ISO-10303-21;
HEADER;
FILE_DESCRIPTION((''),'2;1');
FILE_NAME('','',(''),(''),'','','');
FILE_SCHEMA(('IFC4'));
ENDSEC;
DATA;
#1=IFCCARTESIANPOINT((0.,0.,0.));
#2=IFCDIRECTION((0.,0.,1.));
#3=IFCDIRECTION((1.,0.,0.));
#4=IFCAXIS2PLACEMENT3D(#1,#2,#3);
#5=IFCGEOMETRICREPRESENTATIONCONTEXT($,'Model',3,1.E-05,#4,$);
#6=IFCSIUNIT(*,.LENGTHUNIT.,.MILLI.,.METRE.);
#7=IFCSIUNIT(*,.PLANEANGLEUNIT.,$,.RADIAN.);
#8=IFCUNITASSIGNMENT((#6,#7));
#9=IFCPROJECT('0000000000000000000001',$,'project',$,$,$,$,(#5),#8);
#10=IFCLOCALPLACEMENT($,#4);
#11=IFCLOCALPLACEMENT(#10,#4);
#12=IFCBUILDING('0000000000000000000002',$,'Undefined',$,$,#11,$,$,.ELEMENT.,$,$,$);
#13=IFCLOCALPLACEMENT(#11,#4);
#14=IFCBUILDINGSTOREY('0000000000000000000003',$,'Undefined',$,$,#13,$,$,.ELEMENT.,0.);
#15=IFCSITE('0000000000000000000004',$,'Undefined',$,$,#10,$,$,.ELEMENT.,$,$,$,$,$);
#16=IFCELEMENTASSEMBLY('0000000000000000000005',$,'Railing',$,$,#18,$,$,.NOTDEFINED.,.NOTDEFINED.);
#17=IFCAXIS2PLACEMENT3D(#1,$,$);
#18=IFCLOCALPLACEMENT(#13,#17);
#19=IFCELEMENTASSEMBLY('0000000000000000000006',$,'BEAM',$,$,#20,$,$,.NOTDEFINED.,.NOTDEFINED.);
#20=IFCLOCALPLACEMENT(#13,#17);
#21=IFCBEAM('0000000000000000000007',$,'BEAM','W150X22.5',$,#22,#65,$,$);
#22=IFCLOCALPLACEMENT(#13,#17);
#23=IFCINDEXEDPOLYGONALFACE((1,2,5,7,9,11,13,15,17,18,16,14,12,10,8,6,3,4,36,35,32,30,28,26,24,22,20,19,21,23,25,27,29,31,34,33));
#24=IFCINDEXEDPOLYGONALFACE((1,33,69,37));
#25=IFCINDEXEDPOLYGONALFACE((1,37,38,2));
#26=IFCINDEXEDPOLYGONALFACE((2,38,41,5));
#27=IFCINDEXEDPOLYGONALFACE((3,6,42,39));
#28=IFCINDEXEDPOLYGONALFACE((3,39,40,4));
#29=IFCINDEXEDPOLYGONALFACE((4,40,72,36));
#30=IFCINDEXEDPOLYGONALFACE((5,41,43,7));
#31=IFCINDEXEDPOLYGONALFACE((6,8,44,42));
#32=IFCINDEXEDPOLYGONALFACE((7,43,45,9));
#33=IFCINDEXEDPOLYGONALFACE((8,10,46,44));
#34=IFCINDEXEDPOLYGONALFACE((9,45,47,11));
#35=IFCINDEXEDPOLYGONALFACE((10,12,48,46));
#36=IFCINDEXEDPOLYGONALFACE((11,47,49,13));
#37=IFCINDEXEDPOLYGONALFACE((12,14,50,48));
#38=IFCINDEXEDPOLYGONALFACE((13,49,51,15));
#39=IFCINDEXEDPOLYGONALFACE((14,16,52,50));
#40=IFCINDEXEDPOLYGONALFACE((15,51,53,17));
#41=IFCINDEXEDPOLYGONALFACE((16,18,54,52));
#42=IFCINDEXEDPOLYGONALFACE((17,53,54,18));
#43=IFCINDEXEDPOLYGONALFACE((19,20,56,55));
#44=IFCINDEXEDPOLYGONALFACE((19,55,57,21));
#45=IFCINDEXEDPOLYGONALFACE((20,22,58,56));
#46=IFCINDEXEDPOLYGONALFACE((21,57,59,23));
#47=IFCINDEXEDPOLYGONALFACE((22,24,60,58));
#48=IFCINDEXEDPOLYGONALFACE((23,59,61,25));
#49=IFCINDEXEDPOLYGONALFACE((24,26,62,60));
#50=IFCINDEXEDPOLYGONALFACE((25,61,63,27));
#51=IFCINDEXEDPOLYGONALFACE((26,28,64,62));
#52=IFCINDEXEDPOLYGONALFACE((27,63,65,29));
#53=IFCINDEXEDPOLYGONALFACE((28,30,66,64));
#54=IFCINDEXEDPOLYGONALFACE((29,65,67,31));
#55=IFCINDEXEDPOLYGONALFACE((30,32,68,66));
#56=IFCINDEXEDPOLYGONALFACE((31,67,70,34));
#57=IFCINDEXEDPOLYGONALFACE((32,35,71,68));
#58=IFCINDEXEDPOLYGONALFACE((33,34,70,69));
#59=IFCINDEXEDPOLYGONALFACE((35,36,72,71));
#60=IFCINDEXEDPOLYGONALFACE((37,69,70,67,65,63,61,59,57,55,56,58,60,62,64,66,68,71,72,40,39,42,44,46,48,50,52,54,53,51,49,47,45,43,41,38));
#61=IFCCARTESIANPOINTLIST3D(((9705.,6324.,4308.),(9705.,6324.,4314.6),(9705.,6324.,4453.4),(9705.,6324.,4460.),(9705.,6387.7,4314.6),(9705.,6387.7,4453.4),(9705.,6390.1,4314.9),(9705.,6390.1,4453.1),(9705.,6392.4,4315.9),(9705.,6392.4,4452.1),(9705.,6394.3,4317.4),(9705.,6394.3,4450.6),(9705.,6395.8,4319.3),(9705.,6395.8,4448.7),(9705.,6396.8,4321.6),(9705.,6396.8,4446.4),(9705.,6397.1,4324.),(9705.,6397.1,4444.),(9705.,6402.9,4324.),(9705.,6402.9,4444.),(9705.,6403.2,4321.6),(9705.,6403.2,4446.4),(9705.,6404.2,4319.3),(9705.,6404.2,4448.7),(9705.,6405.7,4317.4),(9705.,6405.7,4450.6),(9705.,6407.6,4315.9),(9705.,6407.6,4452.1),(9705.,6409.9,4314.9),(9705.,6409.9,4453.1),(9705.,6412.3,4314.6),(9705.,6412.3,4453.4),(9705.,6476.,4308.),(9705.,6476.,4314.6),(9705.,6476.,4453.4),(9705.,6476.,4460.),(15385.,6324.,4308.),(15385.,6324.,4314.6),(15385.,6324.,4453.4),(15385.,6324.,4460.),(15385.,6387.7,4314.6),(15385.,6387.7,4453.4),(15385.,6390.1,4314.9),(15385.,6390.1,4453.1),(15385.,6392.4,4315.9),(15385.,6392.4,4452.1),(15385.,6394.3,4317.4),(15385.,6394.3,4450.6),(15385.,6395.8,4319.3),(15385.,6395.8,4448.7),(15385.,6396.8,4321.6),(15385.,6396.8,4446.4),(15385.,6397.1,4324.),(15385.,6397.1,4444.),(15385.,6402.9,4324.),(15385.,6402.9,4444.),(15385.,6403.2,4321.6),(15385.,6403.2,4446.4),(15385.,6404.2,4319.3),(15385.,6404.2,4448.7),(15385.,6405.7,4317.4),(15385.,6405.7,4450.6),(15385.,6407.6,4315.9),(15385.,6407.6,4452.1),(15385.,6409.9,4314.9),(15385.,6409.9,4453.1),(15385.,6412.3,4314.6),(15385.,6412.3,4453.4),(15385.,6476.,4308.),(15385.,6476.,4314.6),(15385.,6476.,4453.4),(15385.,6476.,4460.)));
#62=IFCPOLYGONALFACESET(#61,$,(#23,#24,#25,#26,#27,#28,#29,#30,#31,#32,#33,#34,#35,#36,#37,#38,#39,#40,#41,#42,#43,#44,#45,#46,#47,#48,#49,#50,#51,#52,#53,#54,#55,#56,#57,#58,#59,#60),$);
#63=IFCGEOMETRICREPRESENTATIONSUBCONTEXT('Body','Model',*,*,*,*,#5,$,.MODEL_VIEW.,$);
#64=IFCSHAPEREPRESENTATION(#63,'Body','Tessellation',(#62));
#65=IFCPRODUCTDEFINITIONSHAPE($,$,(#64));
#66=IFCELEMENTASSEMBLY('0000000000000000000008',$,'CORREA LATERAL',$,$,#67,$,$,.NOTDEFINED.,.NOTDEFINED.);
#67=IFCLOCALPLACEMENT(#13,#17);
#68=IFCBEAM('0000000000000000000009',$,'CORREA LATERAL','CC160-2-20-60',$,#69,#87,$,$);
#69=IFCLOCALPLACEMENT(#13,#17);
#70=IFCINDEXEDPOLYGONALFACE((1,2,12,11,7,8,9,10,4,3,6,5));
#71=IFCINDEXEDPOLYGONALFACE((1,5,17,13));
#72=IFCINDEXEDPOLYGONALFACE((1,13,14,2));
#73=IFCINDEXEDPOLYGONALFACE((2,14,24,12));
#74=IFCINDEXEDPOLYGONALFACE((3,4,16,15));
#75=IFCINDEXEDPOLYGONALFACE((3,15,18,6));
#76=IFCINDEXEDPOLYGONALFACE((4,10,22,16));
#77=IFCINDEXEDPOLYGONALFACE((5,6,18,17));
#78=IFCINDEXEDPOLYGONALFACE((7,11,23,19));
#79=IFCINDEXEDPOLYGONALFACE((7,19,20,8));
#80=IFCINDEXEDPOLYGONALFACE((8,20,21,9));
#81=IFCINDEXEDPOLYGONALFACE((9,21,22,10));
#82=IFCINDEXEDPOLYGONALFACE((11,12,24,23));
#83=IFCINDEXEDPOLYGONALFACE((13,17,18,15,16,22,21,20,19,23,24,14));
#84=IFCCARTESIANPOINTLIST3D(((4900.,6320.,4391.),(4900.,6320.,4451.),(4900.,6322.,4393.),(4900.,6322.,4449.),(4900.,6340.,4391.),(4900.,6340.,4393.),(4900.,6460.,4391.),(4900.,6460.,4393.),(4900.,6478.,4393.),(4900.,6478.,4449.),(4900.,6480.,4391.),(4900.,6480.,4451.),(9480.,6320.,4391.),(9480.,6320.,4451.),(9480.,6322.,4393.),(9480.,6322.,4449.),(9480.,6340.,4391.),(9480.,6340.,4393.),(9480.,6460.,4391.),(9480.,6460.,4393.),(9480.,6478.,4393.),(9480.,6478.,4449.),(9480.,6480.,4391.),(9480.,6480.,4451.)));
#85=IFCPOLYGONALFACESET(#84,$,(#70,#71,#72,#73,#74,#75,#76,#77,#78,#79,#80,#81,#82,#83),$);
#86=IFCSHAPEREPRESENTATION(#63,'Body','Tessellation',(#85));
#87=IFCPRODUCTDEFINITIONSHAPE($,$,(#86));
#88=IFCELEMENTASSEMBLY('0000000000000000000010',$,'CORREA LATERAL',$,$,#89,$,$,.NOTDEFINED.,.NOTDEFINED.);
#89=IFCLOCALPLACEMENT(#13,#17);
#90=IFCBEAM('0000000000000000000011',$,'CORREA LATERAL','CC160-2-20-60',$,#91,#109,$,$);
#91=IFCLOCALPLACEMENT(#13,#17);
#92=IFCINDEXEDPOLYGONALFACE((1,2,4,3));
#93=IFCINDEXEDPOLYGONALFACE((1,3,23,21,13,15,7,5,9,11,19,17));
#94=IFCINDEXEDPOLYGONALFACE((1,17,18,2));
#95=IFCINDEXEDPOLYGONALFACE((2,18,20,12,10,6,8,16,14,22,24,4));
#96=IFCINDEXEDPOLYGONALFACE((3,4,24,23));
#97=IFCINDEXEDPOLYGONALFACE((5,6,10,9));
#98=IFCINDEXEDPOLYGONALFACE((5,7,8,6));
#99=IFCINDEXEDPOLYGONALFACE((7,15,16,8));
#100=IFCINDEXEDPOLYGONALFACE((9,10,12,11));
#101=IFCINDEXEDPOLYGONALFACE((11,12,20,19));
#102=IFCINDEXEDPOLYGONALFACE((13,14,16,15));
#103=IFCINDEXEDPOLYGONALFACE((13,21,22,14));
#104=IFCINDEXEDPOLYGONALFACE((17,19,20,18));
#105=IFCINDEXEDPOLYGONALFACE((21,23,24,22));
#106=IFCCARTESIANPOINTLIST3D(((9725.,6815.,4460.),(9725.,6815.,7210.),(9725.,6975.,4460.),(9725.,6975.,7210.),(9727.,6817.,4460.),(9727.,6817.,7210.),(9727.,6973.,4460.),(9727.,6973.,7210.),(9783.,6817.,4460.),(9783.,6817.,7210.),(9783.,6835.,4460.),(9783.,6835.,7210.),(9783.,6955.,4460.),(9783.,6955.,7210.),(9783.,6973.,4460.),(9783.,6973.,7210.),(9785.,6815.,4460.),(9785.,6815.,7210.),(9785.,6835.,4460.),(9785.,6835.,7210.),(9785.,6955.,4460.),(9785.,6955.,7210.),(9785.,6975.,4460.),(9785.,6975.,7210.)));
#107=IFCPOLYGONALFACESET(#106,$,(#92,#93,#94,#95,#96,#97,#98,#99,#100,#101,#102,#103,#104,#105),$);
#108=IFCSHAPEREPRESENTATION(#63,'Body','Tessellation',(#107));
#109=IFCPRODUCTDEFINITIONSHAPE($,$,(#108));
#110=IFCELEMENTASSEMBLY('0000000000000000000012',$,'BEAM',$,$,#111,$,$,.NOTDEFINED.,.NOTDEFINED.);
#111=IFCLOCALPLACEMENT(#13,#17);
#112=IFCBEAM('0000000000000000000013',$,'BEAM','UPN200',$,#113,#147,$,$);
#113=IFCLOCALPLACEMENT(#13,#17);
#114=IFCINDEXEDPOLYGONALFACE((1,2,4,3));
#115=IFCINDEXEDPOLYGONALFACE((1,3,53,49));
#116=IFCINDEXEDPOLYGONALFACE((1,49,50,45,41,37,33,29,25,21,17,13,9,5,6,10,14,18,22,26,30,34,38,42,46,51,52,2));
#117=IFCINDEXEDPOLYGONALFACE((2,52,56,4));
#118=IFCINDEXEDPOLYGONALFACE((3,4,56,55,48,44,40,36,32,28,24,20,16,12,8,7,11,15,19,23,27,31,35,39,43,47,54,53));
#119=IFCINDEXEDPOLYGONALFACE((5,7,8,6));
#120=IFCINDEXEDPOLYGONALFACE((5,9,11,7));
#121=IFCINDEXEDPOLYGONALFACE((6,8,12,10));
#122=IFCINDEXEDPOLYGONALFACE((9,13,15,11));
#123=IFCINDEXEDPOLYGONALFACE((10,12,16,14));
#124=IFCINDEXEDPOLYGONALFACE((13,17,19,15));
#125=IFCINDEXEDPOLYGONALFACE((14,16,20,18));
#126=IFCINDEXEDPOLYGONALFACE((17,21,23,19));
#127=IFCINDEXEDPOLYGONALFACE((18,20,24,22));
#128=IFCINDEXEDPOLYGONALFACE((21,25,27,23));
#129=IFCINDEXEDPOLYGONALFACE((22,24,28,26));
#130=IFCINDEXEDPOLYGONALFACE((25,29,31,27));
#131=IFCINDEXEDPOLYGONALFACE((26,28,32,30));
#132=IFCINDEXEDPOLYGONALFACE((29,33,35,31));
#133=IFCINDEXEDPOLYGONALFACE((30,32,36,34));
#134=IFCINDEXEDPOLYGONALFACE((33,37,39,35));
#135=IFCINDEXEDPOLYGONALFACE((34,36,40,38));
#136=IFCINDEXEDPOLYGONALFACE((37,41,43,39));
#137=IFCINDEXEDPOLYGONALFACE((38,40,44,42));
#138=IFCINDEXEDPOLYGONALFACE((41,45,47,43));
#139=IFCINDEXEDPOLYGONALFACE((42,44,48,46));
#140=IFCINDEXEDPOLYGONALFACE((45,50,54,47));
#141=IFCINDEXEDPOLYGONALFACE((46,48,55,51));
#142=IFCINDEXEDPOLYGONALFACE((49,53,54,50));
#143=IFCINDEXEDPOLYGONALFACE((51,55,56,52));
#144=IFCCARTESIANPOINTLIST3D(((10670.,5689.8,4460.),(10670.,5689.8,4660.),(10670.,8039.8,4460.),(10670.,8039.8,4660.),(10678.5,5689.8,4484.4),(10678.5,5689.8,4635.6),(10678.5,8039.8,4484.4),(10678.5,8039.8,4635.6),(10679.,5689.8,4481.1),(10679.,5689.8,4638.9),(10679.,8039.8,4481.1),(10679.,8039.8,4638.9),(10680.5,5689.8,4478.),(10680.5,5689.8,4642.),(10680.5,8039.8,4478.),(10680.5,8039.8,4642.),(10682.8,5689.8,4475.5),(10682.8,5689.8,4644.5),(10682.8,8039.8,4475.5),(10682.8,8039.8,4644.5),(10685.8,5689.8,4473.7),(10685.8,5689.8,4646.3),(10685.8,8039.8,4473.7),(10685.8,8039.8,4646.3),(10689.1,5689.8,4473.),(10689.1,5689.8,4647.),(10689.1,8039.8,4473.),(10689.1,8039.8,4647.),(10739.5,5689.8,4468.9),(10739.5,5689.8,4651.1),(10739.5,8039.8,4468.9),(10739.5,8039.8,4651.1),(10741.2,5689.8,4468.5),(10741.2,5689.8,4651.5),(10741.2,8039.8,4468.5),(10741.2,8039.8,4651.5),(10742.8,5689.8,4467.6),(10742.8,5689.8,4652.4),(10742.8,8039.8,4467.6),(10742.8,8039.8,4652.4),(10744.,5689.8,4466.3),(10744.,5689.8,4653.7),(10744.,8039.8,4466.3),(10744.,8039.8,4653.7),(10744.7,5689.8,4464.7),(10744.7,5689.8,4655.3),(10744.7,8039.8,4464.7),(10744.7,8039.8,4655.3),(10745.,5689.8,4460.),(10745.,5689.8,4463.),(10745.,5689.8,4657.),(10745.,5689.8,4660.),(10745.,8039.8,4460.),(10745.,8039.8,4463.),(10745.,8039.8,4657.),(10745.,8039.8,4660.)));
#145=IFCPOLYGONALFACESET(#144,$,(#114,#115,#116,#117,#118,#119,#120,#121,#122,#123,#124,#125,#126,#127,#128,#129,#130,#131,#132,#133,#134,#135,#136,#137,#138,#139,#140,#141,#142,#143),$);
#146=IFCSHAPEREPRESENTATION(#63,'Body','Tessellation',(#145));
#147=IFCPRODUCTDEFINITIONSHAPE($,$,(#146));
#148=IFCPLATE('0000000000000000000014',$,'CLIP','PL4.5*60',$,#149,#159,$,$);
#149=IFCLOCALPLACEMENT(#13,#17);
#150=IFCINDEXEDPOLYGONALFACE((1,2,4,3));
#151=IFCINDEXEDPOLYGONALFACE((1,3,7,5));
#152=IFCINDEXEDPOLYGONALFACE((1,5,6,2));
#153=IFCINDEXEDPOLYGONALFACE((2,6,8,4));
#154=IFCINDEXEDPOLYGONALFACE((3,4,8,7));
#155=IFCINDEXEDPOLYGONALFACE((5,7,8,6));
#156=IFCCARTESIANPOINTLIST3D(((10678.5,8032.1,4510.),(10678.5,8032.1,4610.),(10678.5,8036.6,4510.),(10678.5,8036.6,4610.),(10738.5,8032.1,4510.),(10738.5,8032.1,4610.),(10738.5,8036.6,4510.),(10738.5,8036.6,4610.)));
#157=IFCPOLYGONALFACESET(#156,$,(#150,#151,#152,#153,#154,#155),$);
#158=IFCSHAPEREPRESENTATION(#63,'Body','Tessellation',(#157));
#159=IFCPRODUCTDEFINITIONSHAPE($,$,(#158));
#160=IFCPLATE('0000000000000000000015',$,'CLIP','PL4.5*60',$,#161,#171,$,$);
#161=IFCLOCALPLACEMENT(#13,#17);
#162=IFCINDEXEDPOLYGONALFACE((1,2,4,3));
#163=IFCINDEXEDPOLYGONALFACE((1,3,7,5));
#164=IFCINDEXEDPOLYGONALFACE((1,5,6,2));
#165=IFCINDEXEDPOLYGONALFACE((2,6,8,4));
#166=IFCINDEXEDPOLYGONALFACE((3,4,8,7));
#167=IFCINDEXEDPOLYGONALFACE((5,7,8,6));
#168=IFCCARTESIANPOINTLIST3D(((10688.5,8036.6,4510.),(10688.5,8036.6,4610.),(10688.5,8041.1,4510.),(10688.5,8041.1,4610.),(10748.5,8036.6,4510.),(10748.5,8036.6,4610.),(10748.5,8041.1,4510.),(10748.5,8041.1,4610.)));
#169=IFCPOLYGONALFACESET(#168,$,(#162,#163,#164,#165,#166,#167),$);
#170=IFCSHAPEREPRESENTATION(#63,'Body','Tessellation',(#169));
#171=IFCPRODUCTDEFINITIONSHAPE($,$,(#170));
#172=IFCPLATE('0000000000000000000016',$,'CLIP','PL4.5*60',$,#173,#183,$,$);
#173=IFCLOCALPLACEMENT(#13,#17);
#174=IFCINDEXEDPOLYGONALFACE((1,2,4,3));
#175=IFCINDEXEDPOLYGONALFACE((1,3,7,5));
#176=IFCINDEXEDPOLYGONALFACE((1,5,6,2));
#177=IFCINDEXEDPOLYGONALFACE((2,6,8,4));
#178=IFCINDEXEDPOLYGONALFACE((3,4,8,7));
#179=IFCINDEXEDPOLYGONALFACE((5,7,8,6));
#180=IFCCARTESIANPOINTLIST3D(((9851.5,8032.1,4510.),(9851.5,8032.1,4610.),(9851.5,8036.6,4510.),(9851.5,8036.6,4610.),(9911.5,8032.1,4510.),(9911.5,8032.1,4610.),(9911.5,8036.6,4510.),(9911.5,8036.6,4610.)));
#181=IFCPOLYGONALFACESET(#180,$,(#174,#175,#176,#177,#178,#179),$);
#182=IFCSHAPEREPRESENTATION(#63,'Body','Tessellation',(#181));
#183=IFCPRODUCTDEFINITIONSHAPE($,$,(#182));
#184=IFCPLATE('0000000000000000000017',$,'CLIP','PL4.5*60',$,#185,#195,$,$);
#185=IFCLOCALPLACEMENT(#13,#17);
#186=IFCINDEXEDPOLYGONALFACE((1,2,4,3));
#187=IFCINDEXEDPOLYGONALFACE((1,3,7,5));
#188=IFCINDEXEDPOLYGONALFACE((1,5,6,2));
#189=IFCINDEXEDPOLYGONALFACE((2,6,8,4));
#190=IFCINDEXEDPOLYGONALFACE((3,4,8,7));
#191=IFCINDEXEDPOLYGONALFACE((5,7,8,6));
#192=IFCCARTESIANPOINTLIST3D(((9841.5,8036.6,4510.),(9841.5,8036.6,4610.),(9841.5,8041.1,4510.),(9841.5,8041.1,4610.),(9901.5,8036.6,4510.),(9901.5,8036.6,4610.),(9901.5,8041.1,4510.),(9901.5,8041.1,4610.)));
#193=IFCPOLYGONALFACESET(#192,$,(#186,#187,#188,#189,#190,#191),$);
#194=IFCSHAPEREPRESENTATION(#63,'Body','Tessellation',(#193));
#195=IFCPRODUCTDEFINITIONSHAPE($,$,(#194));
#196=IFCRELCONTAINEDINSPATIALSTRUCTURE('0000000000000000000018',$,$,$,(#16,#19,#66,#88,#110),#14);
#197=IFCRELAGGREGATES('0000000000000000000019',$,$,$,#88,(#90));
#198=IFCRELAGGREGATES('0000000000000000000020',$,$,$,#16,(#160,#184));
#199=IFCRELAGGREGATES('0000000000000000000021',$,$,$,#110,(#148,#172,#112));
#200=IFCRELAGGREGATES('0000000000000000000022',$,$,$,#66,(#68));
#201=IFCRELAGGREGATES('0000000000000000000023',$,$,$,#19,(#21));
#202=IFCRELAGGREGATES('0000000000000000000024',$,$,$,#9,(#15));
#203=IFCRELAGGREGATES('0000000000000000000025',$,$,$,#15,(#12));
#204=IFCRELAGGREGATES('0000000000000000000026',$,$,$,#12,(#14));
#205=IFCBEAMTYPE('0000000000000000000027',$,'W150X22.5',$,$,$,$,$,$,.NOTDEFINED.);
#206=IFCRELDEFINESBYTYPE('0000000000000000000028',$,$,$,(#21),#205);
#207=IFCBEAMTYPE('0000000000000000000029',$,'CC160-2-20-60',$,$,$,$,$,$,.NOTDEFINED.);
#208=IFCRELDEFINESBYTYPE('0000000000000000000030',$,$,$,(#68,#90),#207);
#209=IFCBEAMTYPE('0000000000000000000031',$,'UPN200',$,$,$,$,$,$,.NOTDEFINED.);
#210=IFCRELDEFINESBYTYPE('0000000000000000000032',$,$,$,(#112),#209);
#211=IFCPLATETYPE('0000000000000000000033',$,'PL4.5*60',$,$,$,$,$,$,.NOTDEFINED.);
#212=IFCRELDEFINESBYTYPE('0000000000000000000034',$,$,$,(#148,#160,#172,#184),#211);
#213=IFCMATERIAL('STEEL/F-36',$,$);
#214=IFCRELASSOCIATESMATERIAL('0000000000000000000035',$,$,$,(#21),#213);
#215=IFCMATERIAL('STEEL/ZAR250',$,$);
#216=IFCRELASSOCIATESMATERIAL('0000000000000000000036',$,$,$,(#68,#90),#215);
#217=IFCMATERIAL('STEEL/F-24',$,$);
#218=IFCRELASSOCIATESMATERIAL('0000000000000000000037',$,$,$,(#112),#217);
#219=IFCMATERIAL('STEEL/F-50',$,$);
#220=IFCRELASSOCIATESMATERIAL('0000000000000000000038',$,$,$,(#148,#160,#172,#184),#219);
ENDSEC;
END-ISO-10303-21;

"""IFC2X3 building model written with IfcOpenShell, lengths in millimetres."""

from ifc_helpers import new_model, si_unit, frame, origin_with_axes, origin_2d_with_axis, place, context, subcontext, project, spatial, polyline, i_section, u_section, c_section, outline, extrude, material, type_object, element, aggregate, save


model = new_model("IFC2X3")

# Units and contexts
model_context = context("Model", 3, precision=1e-05, world=origin_with_axes())
body_context = subcontext(model_context, "Body", "Model", "MODEL_VIEW")
ifc_project = project(units=[si_unit("LENGTHUNIT", "METRE", prefix="MILLI"), si_unit("PLANEANGLEUNIT", "RADIAN")], contexts=[model_context])

# Site, building, storey
site_placement = place(None, origin_with_axes())
site = spatial("IfcSite", under=ifc_project, at=site_placement, Name="Undefined", CompositionType="ELEMENT")
building_placement = place(site_placement, origin_with_axes())
building = spatial("IfcBuilding", under=site, at=building_placement, Name="Undefined", CompositionType="ELEMENT")
storey_placement = place(building_placement, origin_with_axes())
storey = spatial("IfcBuildingStorey", under=building, at=storey_placement, Name="Undefined", CompositionType="ELEMENT", Elevation=0.0)

# Element assembly
assembly_1_placement = place(storey_placement, origin_with_axes())
assembly_1 = element("IfcElementAssembly", 1, at=assembly_1_placement, inside=storey, Name="Railing", AssemblyPlace="NOTDEFINED", PredefinedType="NOTDEFINED")
ifc_material_1 = material(Name="STEEL/F-24")

# Element assemblies, beams
assembly_2_placement = place(storey_placement, origin_with_axes())
assembly_2 = element("IfcElementAssembly", 2, at=assembly_2_placement, inside=storey, Name="BEAM", AssemblyPlace="NOTDEFINED", PredefinedType="NOTDEFINED")
ifc_material_2 = material(Name="STEEL/F-36")
beam_type_1 = type_object("IfcBeamType", Name="W150X22.5", PredefinedType="NOTDEFINED")
beam_1_placement = place(assembly_2_placement, frame((9705.0, 6400.0, 4384.0), z_axis=(0.0, 0.0, 1.0), x_axis=(1.0, 0.0, 0.0)))
beam_1 = element("IfcBeam", 3, at=beam_1_placement, type_object=beam_type_1, material=ifc_material_2, Name="BEAM", Description="W150X22.5", context=body_context, shape_type="SweptSolid", body=[
    extrude(i_section(OverallWidth=152.0, OverallDepth=152.0, WebThickness=5.8, FlangeThickness=6.6, FilletRadius=9.4, at=origin_2d_with_axis()), frame((5680.0, 0.0, 0.0), z_axis=(-1.0, 0.0, 0.0), x_axis=(0.0, -1.0, 0.0)), (0.0, 0.0, 1.0), 5680.0),
])
assembly_3_placement = place(storey_placement, origin_with_axes())
assembly_3 = element("IfcElementAssembly", 4, at=assembly_3_placement, inside=storey, Name="CORREA LATERAL", AssemblyPlace="NOTDEFINED", PredefinedType="NOTDEFINED")
ifc_material_3 = material(Name="STEEL/ZAR250")
beam_type_2 = type_object("IfcBeamType", Name="CC160-2-20-60", PredefinedType="NOTDEFINED")
beam_2_placement = place(assembly_3_placement, frame((9480.0, 6400.0, 4421.0), z_axis=(0.0, 1.0, 0.0), x_axis=(-1.0, 0.0, 0.0)))
beam_2 = element("IfcBeam", 5, at=beam_2_placement, type_object=beam_type_2, material=ifc_material_3, Name="CORREA LATERAL", Description="CC160-2-20-60", context=body_context, shape_type="SweptSolid", body=[
    extrude(c_section(Depth=160.0, Width=60.0, WallThickness=2.0, Girth=20.0, at=origin_2d_with_axis()), frame((4580.0, 0.0, 0.0), z_axis=(-1.0, 0.0, 0.0), x_axis=(0.0, -1.0, 0.0)), (0.0, 0.0, 1.0), 4580.0),
])
assembly_4_placement = place(storey_placement, origin_with_axes())
assembly_4 = element("IfcElementAssembly", 6, at=assembly_4_placement, inside=storey, Name="CORREA LATERAL", AssemblyPlace="NOTDEFINED", PredefinedType="NOTDEFINED")
beam_3_placement = place(assembly_4_placement, frame((9755.0, 6895.0, 4460.0), z_axis=(0.0, -1.0, 0.0), x_axis=(0.0, 0.0, 1.0)))
beam_3 = element("IfcBeam", 7, at=beam_3_placement, type_object=beam_type_2, material=ifc_material_3, Name="CORREA LATERAL", Description="CC160-2-20-60", context=body_context, shape_type="SweptSolid", body=[
    extrude(c_section(Depth=160.0, Width=60.0, WallThickness=2.0, Girth=20.0, at=origin_2d_with_axis()), frame((2750.0, 0.0, 0.0), z_axis=(-1.0, 0.0, 0.0), x_axis=(0.0, -1.0, 0.0)), (0.0, 0.0, 1.0), 2750.0),
])
aggregate(assembly_4, [beam_3])

# Element assembly, beam, plate
assembly_5_placement = place(storey_placement, origin_with_axes())
assembly_5 = element("IfcElementAssembly", 8, at=assembly_5_placement, inside=storey, Name="BEAM", AssemblyPlace="NOTDEFINED", PredefinedType="NOTDEFINED")
beam_type_3 = type_object("IfcBeamType", Name="UPN200", PredefinedType="NOTDEFINED")
beam_4_placement = place(assembly_5_placement, frame((10707.5, 8039.8, 4560.0), z_axis=(0.0, 0.0, -1.0), x_axis=(0.0, -1.0, 0.0)))
beam_4 = element("IfcBeam", 9, at=beam_4_placement, type_object=beam_type_3, material=ifc_material_1, Name="BEAM", Description="UPN200", context=body_context, shape_type="SweptSolid", body=[
    extrude(u_section(Depth=200.0, FlangeWidth=75.0, WebThickness=8.5, FlangeThickness=11.5, FilletRadius=11.5, EdgeRadius=6.0, FlangeSlope=0.07983, at=origin_2d_with_axis()), frame((2350.0, 0.0, 0.0), z_axis=(-1.0, 0.0, 0.0), x_axis=(0.0, -1.0, 0.0)), (0.0, 0.0, 1.0), 2350.0),
])
ifc_material_4 = material(Name="STEEL/F-50")
plate_type_1 = type_object("IfcPlateType", Name="PL4.5*60", PredefinedType="NOTDEFINED")
plate_1_placement = place(assembly_5_placement, frame((10738.5, 8034.3, 4510.0), z_axis=(0.0, 1.0, 0.0), x_axis=(-1.0, 0.0, 0.0)))
plate_1 = element("IfcPlate", 10, at=plate_1_placement, type_object=plate_type_1, material=ifc_material_4, Name="CLIP", Description="PL4.5*60", context=body_context, shape_type="SweptSolid", body=[
    extrude(outline(polyline([(0.0, 0.0), (60.0, 0.0), (60.0, 100.0), (0.0, 100.0), (0.0, 0.0)])), frame((0.0, 0.0, -2.2), z_axis=(0.0, 0.0, 1.0), x_axis=(1.0, 0.0, 0.0)), (0.0, 0.0, 1.0), 4.5),
])

# Plates
plate_2_placement = place(assembly_1_placement, frame((10748.5, 8038.8, 4510.0), z_axis=(0.0, 1.0, 0.0), x_axis=(-1.0, 0.0, 0.0)))
plate_2 = element("IfcPlate", 11, at=plate_2_placement, type_object=plate_type_1, material=ifc_material_4, Name="CLIP", Description="PL4.5*60", context=body_context, shape_type="SweptSolid", body=[
    extrude(outline(polyline([(0.0, 0.0), (60.0, 0.0), (60.0, 100.0), (0.0, 100.0), (0.0, 0.0)])), frame((0.0, 0.0, -2.2), z_axis=(0.0, 0.0, 1.0), x_axis=(1.0, 0.0, 0.0)), (0.0, 0.0, 1.0), 4.5),
])
plate_3_placement = place(assembly_5_placement, frame((9851.5, 8034.3, 4510.0), z_axis=(0.0, -1.0, 0.0), x_axis=(1.0, 0.0, 0.0)))
plate_3 = element("IfcPlate", 12, at=plate_3_placement, type_object=plate_type_1, material=ifc_material_4, Name="CLIP", Description="PL4.5*60", context=body_context, shape_type="SweptSolid", body=[
    extrude(outline(polyline([(0.0, 0.0), (60.0, 0.0), (60.0, 100.0), (0.0, 100.0), (0.0, 0.0)])), frame((0.0, 0.0, -2.2), z_axis=(0.0, 0.0, 1.0), x_axis=(1.0, 0.0, 0.0)), (0.0, 0.0, 1.0), 4.5),
])
plate_4_placement = place(assembly_1_placement, frame((9841.5, 8038.8, 4510.0), z_axis=(0.0, -1.0, 0.0), x_axis=(1.0, 0.0, 0.0)))
plate_4 = element("IfcPlate", 13, at=plate_4_placement, type_object=plate_type_1, material=ifc_material_4, Name="CLIP", Description="PL4.5*60", context=body_context, shape_type="SweptSolid", body=[
    extrude(outline(polyline([(0.0, 0.0), (60.0, 0.0), (60.0, 100.0), (0.0, 100.0), (0.0, 0.0)])), frame((0.0, 0.0, -2.2), z_axis=(0.0, 0.0, 1.0), x_axis=(1.0, 0.0, 0.0)), (0.0, 0.0, 1.0), 4.5),
])
aggregate(assembly_1, [plate_2, plate_4])

aggregate(assembly_5, [plate_1, plate_3, beam_4])
aggregate(assembly_3, [beam_2])

aggregate(assembly_2, [beam_1])

save(model, "model.ifc")
